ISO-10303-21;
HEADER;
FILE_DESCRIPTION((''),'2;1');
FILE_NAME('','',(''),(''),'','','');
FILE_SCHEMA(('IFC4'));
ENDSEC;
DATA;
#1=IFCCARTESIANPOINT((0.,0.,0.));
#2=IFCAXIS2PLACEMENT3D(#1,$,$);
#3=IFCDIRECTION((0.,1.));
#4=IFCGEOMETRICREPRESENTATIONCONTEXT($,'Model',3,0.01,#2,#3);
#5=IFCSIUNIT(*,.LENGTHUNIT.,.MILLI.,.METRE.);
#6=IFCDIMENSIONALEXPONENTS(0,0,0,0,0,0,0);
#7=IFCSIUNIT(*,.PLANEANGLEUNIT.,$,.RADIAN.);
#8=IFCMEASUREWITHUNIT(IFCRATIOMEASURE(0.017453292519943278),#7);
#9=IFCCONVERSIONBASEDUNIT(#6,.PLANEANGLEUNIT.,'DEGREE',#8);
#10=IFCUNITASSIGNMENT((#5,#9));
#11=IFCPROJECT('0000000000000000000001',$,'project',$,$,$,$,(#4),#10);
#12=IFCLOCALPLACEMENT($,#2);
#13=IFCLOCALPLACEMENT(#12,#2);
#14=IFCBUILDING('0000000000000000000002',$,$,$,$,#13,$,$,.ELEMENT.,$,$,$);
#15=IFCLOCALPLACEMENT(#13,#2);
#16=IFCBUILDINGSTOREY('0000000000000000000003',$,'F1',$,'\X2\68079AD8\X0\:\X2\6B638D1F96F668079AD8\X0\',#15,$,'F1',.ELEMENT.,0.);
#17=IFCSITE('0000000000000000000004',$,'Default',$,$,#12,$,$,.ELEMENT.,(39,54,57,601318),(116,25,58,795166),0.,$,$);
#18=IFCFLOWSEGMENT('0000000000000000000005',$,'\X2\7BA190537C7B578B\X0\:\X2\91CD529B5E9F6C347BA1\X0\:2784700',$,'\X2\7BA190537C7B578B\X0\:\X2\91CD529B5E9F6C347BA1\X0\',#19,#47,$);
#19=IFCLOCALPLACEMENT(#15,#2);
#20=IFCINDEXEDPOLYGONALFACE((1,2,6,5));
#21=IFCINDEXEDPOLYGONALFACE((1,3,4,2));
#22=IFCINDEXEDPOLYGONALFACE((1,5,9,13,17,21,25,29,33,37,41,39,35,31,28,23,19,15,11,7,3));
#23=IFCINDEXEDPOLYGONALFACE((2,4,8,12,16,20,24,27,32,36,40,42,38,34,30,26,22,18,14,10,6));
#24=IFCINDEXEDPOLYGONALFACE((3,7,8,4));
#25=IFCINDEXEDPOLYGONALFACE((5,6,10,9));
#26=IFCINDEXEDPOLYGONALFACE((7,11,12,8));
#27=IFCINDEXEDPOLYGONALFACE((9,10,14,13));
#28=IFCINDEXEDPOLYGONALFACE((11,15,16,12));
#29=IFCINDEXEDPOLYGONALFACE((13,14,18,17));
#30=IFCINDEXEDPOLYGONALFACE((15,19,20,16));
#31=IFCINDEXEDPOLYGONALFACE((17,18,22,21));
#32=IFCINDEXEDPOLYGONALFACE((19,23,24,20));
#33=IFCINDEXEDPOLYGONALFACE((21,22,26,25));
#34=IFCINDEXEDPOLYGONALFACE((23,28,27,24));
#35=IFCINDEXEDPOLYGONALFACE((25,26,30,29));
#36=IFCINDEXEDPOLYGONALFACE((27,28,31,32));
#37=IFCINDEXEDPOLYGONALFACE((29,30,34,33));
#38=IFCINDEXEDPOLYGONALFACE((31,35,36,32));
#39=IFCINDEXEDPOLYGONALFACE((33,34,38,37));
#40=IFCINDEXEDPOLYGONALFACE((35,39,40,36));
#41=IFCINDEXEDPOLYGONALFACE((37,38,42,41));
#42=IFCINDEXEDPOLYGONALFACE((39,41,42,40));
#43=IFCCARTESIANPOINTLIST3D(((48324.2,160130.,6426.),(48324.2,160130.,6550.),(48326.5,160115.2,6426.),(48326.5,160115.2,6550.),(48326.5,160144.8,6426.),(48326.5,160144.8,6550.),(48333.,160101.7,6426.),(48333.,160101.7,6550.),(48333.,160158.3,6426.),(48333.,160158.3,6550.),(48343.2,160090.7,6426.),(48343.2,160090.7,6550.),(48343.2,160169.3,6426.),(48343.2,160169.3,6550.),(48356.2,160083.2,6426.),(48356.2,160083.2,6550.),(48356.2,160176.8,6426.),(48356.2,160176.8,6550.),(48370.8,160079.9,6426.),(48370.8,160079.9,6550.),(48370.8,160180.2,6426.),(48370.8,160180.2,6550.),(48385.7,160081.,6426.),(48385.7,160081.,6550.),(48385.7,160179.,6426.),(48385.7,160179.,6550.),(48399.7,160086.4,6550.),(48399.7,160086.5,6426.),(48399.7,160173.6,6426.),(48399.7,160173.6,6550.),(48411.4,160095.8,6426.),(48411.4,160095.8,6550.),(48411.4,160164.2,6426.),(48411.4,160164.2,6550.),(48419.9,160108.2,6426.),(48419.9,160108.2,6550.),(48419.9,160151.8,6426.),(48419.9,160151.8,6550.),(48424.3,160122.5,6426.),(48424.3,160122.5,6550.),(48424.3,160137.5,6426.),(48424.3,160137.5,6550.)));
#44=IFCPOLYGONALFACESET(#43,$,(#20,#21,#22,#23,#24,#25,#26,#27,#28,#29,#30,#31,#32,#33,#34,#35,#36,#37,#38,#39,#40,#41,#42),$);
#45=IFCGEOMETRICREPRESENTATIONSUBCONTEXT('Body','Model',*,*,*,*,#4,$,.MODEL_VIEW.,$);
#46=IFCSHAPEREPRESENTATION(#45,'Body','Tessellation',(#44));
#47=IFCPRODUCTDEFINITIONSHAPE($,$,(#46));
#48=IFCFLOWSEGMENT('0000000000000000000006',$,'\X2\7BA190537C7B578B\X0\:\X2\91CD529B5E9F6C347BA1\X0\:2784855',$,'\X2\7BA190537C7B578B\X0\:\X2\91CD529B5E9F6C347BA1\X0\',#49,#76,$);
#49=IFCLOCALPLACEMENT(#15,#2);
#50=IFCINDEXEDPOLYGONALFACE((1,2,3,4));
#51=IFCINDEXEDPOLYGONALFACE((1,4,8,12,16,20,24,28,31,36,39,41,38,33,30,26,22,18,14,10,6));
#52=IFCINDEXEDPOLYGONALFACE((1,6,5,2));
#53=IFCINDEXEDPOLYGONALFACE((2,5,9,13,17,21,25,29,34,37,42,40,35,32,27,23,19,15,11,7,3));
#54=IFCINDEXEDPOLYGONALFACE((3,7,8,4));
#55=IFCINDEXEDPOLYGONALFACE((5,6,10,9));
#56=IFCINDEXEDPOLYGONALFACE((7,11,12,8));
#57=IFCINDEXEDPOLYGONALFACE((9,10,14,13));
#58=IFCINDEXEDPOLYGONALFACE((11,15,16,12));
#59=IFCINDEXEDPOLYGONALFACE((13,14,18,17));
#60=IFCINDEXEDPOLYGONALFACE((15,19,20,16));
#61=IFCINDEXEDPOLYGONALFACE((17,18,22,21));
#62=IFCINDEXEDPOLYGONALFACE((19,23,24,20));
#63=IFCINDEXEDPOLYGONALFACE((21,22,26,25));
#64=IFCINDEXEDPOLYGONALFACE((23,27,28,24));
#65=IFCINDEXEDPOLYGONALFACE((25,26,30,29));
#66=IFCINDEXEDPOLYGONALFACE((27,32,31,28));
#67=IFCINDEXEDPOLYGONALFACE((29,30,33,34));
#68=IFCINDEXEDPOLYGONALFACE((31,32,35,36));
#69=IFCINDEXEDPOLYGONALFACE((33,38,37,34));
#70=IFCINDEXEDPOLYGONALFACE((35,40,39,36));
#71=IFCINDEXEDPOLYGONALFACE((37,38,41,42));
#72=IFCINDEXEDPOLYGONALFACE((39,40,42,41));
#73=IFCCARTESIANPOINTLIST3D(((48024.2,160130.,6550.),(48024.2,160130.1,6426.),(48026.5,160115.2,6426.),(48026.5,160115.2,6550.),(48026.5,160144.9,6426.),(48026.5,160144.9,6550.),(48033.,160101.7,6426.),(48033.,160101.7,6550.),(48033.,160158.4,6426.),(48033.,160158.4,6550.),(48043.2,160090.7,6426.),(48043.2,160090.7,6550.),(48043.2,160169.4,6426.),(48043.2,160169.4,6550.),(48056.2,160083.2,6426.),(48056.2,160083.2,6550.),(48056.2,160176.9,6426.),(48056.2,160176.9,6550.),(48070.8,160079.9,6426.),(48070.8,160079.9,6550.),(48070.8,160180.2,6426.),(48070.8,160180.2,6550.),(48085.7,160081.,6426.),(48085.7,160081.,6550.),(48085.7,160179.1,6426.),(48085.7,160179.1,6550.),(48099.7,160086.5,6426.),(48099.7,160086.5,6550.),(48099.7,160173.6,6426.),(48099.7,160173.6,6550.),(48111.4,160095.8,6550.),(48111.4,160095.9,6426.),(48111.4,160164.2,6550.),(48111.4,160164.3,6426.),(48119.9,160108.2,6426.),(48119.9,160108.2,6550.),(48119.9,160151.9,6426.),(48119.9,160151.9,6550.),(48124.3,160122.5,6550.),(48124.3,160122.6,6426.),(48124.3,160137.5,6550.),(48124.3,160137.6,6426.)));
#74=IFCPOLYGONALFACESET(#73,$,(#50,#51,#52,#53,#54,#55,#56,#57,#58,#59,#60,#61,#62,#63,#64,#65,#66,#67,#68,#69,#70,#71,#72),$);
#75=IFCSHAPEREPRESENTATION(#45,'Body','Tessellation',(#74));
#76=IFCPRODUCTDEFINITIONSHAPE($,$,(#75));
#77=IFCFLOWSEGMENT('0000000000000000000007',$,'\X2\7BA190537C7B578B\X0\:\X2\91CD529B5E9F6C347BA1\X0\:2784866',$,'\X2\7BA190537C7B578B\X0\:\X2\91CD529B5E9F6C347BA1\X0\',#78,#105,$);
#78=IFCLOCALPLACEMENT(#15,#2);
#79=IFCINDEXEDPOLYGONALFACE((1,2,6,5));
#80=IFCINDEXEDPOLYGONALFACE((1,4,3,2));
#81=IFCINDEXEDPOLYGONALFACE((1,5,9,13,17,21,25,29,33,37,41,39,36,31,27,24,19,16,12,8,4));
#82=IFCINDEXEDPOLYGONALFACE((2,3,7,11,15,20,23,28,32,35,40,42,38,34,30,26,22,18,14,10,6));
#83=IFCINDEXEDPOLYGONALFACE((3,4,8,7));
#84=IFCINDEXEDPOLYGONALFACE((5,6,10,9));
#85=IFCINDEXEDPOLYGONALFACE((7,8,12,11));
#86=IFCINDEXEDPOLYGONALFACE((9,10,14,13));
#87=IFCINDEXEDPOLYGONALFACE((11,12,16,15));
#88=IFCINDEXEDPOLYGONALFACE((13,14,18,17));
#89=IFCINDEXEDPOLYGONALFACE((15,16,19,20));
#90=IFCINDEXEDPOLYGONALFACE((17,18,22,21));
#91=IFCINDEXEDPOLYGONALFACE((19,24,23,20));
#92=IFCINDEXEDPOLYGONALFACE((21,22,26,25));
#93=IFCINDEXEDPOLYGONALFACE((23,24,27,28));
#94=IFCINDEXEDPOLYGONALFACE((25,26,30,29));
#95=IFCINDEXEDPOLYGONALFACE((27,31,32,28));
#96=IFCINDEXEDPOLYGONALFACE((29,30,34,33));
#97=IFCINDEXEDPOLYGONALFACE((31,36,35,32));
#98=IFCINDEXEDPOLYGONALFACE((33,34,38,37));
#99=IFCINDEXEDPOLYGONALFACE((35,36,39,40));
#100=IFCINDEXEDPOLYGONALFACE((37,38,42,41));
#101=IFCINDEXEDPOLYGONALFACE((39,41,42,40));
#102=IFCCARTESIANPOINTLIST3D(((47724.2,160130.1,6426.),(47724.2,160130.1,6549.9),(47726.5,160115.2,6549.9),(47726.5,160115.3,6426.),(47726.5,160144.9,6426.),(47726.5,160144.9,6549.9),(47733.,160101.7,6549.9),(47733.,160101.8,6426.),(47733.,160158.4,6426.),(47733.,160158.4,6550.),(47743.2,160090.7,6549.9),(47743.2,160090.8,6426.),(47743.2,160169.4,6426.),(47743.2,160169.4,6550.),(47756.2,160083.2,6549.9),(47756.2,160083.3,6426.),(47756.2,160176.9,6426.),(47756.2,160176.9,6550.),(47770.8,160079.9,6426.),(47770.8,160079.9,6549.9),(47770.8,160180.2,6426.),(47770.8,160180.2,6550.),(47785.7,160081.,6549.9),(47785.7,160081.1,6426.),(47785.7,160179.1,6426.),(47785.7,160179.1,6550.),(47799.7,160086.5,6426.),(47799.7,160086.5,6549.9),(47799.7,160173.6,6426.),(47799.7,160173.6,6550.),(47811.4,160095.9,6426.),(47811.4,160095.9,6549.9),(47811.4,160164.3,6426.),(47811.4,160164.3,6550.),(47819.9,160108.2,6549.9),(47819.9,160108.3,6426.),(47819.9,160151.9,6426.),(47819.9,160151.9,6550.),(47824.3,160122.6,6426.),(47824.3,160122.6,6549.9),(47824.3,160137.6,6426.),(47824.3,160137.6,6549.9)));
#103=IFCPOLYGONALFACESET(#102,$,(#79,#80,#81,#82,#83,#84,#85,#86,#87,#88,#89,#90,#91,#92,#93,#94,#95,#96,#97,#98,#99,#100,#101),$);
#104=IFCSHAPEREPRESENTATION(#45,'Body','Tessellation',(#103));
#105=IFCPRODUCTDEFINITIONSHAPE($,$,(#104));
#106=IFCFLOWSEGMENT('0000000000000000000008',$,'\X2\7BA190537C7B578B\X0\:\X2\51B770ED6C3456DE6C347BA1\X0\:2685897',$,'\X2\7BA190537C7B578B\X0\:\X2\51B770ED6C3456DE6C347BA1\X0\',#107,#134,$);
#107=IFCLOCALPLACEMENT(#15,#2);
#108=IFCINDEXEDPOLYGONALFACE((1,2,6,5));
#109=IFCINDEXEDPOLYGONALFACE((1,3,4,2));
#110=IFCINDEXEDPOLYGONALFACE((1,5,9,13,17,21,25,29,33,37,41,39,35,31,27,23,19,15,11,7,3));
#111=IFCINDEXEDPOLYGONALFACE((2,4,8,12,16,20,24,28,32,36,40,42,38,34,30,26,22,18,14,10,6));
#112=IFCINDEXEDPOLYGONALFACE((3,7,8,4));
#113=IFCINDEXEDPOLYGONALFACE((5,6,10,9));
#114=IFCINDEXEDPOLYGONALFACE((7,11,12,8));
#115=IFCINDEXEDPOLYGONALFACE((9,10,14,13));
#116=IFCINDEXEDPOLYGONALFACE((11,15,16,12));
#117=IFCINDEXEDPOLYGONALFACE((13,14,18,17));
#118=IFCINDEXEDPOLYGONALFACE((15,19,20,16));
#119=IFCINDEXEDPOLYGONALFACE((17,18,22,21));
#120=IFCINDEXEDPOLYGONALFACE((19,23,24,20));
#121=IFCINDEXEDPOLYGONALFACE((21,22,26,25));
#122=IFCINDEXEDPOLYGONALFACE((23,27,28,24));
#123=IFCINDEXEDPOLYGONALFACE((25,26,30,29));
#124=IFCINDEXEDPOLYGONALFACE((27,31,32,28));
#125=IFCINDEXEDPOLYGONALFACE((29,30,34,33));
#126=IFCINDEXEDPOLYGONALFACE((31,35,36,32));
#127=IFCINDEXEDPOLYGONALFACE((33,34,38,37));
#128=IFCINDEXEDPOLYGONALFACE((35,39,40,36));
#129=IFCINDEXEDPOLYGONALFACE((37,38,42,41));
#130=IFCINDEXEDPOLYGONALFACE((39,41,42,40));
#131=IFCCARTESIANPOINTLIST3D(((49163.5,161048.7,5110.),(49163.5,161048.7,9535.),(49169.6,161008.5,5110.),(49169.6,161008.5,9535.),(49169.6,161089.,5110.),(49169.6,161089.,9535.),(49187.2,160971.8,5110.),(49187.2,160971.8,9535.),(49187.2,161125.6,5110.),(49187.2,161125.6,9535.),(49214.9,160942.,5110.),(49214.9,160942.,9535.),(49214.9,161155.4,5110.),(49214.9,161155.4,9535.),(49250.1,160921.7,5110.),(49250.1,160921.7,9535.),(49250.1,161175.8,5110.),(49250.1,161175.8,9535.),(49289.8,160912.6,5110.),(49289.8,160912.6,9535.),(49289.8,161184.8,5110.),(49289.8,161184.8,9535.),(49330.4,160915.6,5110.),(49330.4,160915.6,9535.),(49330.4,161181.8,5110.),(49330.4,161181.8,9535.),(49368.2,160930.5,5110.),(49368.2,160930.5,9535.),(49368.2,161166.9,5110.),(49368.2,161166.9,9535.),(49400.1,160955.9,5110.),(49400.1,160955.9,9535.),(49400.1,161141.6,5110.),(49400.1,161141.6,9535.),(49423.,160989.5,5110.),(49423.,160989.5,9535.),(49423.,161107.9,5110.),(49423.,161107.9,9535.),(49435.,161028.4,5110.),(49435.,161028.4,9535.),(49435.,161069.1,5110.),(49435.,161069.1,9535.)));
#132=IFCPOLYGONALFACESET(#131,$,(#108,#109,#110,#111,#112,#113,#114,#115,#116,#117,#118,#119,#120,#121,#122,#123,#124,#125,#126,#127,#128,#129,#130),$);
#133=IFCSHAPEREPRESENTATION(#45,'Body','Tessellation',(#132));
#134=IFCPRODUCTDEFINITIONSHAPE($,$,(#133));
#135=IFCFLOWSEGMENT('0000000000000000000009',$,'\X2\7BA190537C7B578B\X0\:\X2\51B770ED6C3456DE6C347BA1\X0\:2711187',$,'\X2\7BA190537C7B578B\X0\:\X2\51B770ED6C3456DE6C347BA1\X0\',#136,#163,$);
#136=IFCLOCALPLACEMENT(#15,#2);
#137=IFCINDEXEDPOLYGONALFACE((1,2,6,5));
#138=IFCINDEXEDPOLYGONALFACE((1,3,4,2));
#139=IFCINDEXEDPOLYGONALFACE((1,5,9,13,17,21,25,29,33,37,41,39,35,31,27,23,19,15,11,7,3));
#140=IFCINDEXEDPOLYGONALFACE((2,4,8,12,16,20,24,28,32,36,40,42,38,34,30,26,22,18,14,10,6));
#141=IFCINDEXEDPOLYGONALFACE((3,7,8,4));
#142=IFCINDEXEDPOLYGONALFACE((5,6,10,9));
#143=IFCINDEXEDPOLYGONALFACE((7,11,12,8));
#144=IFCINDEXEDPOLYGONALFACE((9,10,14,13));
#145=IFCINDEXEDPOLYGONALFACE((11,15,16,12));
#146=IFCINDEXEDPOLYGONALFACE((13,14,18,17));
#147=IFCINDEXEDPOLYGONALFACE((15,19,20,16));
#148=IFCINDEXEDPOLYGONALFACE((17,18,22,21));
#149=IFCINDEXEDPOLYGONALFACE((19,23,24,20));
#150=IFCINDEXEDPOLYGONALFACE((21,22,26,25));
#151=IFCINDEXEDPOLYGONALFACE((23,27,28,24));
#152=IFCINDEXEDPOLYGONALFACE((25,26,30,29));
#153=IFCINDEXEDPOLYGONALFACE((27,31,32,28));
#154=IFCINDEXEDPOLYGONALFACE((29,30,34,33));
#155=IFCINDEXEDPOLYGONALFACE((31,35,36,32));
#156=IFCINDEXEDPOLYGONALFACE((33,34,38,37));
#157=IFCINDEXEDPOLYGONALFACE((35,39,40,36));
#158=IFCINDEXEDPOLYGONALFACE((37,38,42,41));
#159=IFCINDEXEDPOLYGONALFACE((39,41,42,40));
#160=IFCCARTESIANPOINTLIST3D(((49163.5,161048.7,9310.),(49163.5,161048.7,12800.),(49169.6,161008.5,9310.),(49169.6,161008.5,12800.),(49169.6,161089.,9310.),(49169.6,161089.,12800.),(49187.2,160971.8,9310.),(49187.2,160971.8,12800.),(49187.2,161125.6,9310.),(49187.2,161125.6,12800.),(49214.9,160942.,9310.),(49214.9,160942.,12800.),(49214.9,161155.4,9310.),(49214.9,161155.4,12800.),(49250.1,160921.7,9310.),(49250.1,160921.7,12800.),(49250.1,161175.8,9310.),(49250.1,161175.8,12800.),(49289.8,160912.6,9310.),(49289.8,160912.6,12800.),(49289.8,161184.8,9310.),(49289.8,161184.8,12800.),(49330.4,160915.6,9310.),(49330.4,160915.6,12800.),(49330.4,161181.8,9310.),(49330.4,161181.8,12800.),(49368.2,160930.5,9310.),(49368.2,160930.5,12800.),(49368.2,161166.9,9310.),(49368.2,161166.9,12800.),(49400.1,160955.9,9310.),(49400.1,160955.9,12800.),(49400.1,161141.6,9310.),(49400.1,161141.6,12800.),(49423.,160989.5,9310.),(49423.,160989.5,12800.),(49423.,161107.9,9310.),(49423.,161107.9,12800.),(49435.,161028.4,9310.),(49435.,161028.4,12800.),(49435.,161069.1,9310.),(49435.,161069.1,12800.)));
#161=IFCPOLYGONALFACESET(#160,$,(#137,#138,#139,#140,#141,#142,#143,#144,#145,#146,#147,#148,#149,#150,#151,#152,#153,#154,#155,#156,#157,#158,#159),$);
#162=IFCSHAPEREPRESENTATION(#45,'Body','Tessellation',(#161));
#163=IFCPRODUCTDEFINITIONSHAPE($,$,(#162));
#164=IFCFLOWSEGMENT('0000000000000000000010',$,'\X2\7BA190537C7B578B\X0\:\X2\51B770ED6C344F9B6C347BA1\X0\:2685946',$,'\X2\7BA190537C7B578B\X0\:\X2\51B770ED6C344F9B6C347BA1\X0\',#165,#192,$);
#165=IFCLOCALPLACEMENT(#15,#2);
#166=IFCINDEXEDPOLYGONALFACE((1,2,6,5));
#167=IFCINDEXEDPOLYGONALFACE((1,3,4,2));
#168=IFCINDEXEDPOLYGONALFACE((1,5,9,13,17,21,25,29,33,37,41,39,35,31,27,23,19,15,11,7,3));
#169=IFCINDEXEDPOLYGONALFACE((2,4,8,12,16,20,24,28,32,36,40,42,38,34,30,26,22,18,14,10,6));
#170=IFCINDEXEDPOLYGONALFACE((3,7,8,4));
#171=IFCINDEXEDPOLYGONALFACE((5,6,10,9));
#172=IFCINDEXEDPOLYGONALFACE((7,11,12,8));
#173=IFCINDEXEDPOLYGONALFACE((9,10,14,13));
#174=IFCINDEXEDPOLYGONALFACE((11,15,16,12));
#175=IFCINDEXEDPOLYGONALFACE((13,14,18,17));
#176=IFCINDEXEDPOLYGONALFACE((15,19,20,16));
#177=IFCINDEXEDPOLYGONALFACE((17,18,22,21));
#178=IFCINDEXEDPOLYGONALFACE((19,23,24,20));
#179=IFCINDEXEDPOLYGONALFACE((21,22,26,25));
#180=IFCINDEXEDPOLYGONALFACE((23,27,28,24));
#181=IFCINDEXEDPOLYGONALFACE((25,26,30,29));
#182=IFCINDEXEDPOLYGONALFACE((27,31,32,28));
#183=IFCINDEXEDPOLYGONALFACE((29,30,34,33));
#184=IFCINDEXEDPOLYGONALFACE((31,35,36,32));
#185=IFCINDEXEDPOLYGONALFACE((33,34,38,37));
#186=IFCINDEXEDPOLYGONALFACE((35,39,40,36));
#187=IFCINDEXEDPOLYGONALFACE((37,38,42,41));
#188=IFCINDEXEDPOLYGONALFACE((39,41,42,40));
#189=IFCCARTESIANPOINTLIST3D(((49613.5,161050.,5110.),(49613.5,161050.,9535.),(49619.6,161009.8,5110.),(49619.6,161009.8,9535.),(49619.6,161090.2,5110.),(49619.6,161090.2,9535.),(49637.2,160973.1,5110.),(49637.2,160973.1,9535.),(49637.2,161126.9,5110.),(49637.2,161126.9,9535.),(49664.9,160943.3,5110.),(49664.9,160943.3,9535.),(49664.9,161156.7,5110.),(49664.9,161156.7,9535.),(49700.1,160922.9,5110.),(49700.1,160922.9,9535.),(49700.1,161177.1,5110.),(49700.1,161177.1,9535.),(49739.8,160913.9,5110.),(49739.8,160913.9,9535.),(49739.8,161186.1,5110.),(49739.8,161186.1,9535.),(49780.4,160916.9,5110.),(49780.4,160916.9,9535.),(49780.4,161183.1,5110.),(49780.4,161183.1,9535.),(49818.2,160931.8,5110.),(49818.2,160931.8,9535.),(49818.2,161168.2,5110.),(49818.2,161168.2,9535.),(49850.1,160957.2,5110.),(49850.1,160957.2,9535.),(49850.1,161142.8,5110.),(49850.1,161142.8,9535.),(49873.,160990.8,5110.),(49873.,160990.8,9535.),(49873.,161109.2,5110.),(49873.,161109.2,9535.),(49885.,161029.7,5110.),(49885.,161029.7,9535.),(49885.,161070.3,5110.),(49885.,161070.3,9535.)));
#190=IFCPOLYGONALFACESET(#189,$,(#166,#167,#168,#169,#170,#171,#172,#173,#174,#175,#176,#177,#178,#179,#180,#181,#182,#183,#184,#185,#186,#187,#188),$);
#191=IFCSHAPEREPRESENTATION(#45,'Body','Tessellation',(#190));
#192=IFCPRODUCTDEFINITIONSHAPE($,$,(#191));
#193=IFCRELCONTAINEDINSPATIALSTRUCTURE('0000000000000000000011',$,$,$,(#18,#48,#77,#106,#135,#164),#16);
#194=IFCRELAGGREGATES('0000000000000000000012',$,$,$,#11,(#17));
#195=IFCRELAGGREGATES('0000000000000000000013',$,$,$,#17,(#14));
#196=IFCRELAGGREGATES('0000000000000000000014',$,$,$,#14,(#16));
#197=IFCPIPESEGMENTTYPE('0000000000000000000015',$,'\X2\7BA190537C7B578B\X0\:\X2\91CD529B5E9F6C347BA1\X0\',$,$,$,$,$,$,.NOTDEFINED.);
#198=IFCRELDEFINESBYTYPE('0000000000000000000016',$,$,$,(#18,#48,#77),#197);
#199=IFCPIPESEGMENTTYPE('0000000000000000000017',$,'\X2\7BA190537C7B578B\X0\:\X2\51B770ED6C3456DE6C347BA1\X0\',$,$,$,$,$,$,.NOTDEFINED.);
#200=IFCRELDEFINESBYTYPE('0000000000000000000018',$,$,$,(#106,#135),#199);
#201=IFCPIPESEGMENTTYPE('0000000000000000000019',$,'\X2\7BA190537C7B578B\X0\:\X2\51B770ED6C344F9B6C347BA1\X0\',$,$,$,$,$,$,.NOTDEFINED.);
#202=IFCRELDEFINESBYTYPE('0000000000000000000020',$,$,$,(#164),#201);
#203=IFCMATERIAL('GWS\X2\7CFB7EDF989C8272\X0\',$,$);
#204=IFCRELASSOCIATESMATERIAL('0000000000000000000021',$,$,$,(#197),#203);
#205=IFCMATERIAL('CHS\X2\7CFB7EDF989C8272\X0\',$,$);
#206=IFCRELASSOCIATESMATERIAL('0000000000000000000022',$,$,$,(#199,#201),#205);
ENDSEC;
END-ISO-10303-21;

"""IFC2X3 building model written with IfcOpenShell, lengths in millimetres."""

from ifc_helpers import new_model, entity, si_unit, converted_unit, direction, frame, origin, origin_2d_with_axis, place, context, subcontext, project, spatial, circle, extrude, material, type_object, element, save


model = new_model("IFC2X3")

# Units and contexts
model_context = context("Model", 3, precision=0.01, world=origin(), true_north=direction((0.0, 1.0)))
body_context = subcontext(model_context, "Body", "Model", "MODEL_VIEW")
ifc_project = project(units=[si_unit("LENGTHUNIT", "METRE", prefix="MILLI"), converted_unit("PLANEANGLEUNIT", "DEGREE", entity("IfcRatioMeasure", 0.017453292519943278), si_unit("PLANEANGLEUNIT", "RADIAN"), dimensions=[0, 0, 0, 0, 0, 0, 0])], contexts=[model_context])

# Site, building, storey
site_placement = place(None, origin())
site = spatial("IfcSite", under=ifc_project, at=site_placement, Name="Default", CompositionType="ELEMENT", RefLatitude=(39, 54, 57, 601318), RefLongitude=(116, 25, 58, 795166), RefElevation=0.0)
building_placement = place(site_placement, origin())
building = spatial("IfcBuilding", under=site, at=building_placement, CompositionType="ELEMENT")
storey_placement = place(building_placement, origin())
storey = spatial("IfcBuildingStorey", under=building, at=storey_placement, Name="F1", ObjectType="标高:正负零标高", LongName="F1", CompositionType="ELEMENT", Elevation=0.0)

# Flow segments
ifc_material_1 = material(Name="GWS系统颜色")
pipe_segment_type_1 = type_object("IfcPipeSegmentType", Name="管道类型:重力废水管", PredefinedType="NOTDEFINED", material=ifc_material_1)
flow_segment_1_placement = place(storey_placement, origin())
element("IfcFlowSegment", 1, at=flow_segment_1_placement, inside=storey, type_object=pipe_segment_type_1, Name="管道类型:重力废水管:2784700", ObjectType="管道类型:重力废水管", context=body_context, shape_type="SweptSolid", body=[
    extrude(circle(Radius=50.3, at=origin_2d_with_axis()), frame((48374.5, 160130.0, 6426.0), z_axis=(0.0, -0.000077, 1.0), x_axis=(-1.0, 0.0, 0.0)), (0.0, 0.0, 1.0), 124.0),
])
flow_segment_2_placement = place(storey_placement, origin())
element("IfcFlowSegment", 2, at=flow_segment_2_placement, inside=storey, type_object=pipe_segment_type_1, Name="管道类型:重力废水管:2784855", ObjectType="管道类型:重力废水管", context=body_context, shape_type="SweptSolid", body=[
    extrude(circle(Radius=50.3, at=origin_2d_with_axis()), frame((48074.5, 160130.1, 6426.0), z_axis=(0.0, -0.000178, 1.0), x_axis=(-1.0, 0.0, 0.0)), (0.0, 0.0, 1.0), 124.0),
])
flow_segment_3_placement = place(storey_placement, origin())
element("IfcFlowSegment", 3, at=flow_segment_3_placement, inside=storey, type_object=pipe_segment_type_1, Name="管道类型:重力废水管:2784866", ObjectType="管道类型:重力废水管", context=body_context, shape_type="SweptSolid", body=[
    extrude(circle(Radius=50.3, at=origin_2d_with_axis()), frame((47774.5, 160130.1, 6426.0), z_axis=(0.0, -0.000268, 1.0), x_axis=(-1.0, 0.0, 0.0)), (0.0, 0.0, 1.0), 123.9),
])
ifc_material_2 = material(Name="CHS系统颜色")
pipe_segment_type_2 = type_object("IfcPipeSegmentType", Name="管道类型:冷热水回水管", PredefinedType="NOTDEFINED", material=ifc_material_2)
flow_segment_4_placement = place(storey_placement, origin())
element("IfcFlowSegment", 4, at=flow_segment_4_placement, inside=storey, type_object=pipe_segment_type_2, Name="管道类型:冷热水回水管:2685897", ObjectType="管道类型:冷热水回水管", context=body_context, shape_type="SweptSolid", body=[
    extrude(circle(Radius=136.5, at=origin_2d_with_axis()), frame((49300.0, 161048.7, 5110.0), z_axis=(0.0, 0.0, 1.0), x_axis=(-1.0, 0.0, 0.0)), (0.0, 0.0, 1.0), 4425.0),
])
flow_segment_5_placement = place(storey_placement, origin())
element("IfcFlowSegment", 5, at=flow_segment_5_placement, inside=storey, type_object=pipe_segment_type_2, Name="管道类型:冷热水回水管:2711187", ObjectType="管道类型:冷热水回水管", context=body_context, shape_type="SweptSolid", body=[
    extrude(circle(Radius=136.5, at=origin_2d_with_axis()), frame((49300.0, 161048.7, 9310.0), z_axis=(0.0, 0.0, 1.0), x_axis=(-1.0, 0.0, 0.0)), (0.0, 0.0, 1.0), 3490.0),
])
pipe_segment_type_3 = type_object("IfcPipeSegmentType", Name="管道类型:冷热水供水管", PredefinedType="NOTDEFINED", material=ifc_material_2)
flow_segment_6_placement = place(storey_placement, origin())
element("IfcFlowSegment", 6, at=flow_segment_6_placement, inside=storey, type_object=pipe_segment_type_3, Name="管道类型:冷热水供水管:2685946", ObjectType="管道类型:冷热水供水管", context=body_context, shape_type="SweptSolid", body=[
    extrude(circle(Radius=136.5, at=origin_2d_with_axis()), frame((49750.0, 161050.0, 5110.0), z_axis=(0.0, 0.0, 1.0), x_axis=(-1.0, 0.0, 0.0)), (0.0, 0.0, 1.0), 4425.0),
])

save(model, "model.ifc")
